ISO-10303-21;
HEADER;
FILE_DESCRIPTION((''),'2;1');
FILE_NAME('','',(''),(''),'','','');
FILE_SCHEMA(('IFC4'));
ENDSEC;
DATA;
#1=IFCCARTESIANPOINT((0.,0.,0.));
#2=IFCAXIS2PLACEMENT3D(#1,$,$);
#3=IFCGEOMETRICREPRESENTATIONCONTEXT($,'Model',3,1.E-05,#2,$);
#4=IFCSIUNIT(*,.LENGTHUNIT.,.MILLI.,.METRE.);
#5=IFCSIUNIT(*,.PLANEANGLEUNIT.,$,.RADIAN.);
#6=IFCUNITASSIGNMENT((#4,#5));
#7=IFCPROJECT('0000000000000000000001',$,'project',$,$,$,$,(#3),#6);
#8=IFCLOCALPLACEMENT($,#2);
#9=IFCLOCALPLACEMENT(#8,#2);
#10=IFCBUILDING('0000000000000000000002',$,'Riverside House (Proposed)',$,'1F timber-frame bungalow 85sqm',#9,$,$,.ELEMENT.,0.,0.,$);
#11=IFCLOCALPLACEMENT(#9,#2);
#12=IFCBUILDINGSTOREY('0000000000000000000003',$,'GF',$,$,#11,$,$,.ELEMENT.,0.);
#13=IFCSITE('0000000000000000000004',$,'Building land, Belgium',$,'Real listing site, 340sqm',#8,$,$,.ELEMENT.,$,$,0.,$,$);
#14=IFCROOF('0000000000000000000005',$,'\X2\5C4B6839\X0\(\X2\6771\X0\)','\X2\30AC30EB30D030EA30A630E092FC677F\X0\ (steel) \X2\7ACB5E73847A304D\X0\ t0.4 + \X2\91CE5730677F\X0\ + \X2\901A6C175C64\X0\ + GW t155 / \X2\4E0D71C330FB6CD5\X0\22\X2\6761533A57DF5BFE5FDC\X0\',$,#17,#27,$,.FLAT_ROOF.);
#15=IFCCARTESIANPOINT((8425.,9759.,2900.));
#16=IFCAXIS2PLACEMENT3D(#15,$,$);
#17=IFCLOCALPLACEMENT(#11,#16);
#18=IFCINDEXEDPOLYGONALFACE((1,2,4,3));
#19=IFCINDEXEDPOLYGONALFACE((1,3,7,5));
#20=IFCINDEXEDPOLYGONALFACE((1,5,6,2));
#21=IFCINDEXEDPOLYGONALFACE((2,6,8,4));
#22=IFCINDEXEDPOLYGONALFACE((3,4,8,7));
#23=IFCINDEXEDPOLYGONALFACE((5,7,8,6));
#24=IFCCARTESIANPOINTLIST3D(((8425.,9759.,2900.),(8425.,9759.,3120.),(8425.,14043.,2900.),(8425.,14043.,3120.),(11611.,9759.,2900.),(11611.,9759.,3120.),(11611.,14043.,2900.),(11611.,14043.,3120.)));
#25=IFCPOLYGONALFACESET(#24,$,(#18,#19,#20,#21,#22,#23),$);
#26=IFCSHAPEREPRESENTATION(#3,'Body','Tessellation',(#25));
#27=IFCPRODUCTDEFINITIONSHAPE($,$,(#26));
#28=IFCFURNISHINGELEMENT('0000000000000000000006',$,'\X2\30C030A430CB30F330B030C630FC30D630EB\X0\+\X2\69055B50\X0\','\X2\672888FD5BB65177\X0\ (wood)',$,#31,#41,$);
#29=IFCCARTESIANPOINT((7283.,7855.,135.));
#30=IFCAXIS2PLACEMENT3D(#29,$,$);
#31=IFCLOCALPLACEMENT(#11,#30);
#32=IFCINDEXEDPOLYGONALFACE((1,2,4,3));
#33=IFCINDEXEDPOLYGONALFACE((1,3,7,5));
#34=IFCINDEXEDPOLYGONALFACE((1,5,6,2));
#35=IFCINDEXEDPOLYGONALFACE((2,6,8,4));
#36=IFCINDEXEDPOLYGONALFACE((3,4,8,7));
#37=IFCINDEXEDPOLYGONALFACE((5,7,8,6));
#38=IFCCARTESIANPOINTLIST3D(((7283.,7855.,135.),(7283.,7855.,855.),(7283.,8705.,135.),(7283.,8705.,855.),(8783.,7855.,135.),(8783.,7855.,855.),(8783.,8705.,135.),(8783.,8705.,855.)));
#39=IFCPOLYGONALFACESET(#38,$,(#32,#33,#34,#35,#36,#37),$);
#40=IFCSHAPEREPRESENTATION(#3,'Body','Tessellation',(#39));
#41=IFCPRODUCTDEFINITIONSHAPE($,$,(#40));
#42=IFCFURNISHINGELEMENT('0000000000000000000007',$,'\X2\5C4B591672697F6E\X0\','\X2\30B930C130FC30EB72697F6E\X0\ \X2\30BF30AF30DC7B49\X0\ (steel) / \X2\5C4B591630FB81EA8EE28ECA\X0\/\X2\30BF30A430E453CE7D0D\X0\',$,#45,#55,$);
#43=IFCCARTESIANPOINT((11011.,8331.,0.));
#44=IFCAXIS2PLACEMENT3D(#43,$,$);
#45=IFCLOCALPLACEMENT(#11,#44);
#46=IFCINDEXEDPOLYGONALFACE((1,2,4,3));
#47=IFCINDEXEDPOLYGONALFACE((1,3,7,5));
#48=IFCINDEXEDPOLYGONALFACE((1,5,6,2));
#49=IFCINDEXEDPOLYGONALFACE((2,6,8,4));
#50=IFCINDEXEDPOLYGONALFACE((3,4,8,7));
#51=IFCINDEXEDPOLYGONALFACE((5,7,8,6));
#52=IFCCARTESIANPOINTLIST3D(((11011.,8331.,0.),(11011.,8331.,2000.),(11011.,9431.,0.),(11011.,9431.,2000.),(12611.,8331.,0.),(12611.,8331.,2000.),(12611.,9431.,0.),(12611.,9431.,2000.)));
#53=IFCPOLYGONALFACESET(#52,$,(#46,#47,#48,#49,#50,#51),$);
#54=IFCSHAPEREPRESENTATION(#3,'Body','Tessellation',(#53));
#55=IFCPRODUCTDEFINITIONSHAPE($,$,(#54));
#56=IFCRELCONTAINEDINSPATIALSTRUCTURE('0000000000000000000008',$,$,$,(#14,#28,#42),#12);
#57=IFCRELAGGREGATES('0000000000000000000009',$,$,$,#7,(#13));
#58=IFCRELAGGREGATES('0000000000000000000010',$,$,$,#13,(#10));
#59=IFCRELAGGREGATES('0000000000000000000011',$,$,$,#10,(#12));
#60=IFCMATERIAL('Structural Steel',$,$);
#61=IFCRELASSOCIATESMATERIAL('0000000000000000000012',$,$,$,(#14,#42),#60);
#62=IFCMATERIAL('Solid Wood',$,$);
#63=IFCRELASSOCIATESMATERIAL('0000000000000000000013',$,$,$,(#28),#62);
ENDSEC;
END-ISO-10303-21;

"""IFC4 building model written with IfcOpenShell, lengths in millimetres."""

from ifc_helpers import new_model, si_unit, frame, frame_2d, origin, place, context, project, spatial, rectangle, extrude, material, element, save


model = new_model("IFC4")

# Units and contexts
model_context = context("Model", 3, precision=1e-05, world=origin())
ifc_project = project(units=[si_unit("LENGTHUNIT", "METRE", prefix="MILLI"), si_unit("PLANEANGLEUNIT", "RADIAN")], contexts=[model_context])

# Site, building, storey
site_placement = place(None, origin())
site = spatial("IfcSite", under=ifc_project, at=site_placement, Name="Building land, Belgium", ObjectType="Real listing site, 340sqm", CompositionType="ELEMENT", RefElevation=0.0)
building_placement = place(site_placement, origin())
building = spatial("IfcBuilding", under=site, at=building_placement, Name="Riverside House (Proposed)", ObjectType="1F timber-frame bungalow 85sqm", CompositionType="ELEMENT", ElevationOfRefHeight=0.0, ElevationOfTerrain=0.0)
storey_placement = place(building_placement, origin())
storey = spatial("IfcBuildingStorey", under=building, at=storey_placement, Name="GF", CompositionType="ELEMENT", Elevation=0.0)

# Shared definitions
ifc_material_1 = material(Name="Solid Wood")

# Roof
ifc_material_2 = material(Name="Structural Steel")
roof_1_placement = place(storey_placement, frame((8425.0, 9759.0, 2900.0)))
element("IfcRoof", 1, at=roof_1_placement, inside=storey, material=ifc_material_2, Name="屋根(東)", Description="ガルバリウム鋼板 (steel) 立平葺き t0.4 + 野地板 + 通気層 + GW t155 / 不燃・法22条区域対応", PredefinedType="FLAT_ROOF", context=model_context, shape_type="SweptSolid", body=[
    extrude(rectangle(XDim=3186.0, YDim=4284.0, at=frame_2d((1593.0, 2142.0))), frame((8425.0, 9759.0, 2900.0)), (0.0, 0.0, 1.0), 220.0),
])

# Furnishing elements
furnishing_1_placement = place(storey_placement, frame((7283.0, 7855.0, 135.0)))
element("IfcFurnishingElement", 2, at=furnishing_1_placement, inside=storey, material=ifc_material_1, Name="ダイニングテーブル+椅子", Description="木製家具 (wood)", context=model_context, shape_type="SweptSolid", body=[
    extrude(rectangle(XDim=1500.0, YDim=850.0, at=frame_2d((750.0, 425.0))), frame((7283.0, 7855.0, 135.0)), (0.0, 0.0, 1.0), 720.0),
])
furnishing_2_placement = place(storey_placement, frame((11011.0, 8331.0, 0.0)))
element("IfcFurnishingElement", 3, at=furnishing_2_placement, inside=storey, material=ifc_material_2, Name="屋外物置", Description="スチール物置 タクボ等 (steel) / 屋外・自転車/タイヤ収納", context=model_context, shape_type="SweptSolid", body=[
    extrude(rectangle(XDim=1600.0, YDim=1100.0, at=frame_2d((800.0, 550.0))), frame((11011.0, 8331.0, 0.0)), (0.0, 0.0, 1.0), 2000.0),
])

save(model, "model.ifc")
